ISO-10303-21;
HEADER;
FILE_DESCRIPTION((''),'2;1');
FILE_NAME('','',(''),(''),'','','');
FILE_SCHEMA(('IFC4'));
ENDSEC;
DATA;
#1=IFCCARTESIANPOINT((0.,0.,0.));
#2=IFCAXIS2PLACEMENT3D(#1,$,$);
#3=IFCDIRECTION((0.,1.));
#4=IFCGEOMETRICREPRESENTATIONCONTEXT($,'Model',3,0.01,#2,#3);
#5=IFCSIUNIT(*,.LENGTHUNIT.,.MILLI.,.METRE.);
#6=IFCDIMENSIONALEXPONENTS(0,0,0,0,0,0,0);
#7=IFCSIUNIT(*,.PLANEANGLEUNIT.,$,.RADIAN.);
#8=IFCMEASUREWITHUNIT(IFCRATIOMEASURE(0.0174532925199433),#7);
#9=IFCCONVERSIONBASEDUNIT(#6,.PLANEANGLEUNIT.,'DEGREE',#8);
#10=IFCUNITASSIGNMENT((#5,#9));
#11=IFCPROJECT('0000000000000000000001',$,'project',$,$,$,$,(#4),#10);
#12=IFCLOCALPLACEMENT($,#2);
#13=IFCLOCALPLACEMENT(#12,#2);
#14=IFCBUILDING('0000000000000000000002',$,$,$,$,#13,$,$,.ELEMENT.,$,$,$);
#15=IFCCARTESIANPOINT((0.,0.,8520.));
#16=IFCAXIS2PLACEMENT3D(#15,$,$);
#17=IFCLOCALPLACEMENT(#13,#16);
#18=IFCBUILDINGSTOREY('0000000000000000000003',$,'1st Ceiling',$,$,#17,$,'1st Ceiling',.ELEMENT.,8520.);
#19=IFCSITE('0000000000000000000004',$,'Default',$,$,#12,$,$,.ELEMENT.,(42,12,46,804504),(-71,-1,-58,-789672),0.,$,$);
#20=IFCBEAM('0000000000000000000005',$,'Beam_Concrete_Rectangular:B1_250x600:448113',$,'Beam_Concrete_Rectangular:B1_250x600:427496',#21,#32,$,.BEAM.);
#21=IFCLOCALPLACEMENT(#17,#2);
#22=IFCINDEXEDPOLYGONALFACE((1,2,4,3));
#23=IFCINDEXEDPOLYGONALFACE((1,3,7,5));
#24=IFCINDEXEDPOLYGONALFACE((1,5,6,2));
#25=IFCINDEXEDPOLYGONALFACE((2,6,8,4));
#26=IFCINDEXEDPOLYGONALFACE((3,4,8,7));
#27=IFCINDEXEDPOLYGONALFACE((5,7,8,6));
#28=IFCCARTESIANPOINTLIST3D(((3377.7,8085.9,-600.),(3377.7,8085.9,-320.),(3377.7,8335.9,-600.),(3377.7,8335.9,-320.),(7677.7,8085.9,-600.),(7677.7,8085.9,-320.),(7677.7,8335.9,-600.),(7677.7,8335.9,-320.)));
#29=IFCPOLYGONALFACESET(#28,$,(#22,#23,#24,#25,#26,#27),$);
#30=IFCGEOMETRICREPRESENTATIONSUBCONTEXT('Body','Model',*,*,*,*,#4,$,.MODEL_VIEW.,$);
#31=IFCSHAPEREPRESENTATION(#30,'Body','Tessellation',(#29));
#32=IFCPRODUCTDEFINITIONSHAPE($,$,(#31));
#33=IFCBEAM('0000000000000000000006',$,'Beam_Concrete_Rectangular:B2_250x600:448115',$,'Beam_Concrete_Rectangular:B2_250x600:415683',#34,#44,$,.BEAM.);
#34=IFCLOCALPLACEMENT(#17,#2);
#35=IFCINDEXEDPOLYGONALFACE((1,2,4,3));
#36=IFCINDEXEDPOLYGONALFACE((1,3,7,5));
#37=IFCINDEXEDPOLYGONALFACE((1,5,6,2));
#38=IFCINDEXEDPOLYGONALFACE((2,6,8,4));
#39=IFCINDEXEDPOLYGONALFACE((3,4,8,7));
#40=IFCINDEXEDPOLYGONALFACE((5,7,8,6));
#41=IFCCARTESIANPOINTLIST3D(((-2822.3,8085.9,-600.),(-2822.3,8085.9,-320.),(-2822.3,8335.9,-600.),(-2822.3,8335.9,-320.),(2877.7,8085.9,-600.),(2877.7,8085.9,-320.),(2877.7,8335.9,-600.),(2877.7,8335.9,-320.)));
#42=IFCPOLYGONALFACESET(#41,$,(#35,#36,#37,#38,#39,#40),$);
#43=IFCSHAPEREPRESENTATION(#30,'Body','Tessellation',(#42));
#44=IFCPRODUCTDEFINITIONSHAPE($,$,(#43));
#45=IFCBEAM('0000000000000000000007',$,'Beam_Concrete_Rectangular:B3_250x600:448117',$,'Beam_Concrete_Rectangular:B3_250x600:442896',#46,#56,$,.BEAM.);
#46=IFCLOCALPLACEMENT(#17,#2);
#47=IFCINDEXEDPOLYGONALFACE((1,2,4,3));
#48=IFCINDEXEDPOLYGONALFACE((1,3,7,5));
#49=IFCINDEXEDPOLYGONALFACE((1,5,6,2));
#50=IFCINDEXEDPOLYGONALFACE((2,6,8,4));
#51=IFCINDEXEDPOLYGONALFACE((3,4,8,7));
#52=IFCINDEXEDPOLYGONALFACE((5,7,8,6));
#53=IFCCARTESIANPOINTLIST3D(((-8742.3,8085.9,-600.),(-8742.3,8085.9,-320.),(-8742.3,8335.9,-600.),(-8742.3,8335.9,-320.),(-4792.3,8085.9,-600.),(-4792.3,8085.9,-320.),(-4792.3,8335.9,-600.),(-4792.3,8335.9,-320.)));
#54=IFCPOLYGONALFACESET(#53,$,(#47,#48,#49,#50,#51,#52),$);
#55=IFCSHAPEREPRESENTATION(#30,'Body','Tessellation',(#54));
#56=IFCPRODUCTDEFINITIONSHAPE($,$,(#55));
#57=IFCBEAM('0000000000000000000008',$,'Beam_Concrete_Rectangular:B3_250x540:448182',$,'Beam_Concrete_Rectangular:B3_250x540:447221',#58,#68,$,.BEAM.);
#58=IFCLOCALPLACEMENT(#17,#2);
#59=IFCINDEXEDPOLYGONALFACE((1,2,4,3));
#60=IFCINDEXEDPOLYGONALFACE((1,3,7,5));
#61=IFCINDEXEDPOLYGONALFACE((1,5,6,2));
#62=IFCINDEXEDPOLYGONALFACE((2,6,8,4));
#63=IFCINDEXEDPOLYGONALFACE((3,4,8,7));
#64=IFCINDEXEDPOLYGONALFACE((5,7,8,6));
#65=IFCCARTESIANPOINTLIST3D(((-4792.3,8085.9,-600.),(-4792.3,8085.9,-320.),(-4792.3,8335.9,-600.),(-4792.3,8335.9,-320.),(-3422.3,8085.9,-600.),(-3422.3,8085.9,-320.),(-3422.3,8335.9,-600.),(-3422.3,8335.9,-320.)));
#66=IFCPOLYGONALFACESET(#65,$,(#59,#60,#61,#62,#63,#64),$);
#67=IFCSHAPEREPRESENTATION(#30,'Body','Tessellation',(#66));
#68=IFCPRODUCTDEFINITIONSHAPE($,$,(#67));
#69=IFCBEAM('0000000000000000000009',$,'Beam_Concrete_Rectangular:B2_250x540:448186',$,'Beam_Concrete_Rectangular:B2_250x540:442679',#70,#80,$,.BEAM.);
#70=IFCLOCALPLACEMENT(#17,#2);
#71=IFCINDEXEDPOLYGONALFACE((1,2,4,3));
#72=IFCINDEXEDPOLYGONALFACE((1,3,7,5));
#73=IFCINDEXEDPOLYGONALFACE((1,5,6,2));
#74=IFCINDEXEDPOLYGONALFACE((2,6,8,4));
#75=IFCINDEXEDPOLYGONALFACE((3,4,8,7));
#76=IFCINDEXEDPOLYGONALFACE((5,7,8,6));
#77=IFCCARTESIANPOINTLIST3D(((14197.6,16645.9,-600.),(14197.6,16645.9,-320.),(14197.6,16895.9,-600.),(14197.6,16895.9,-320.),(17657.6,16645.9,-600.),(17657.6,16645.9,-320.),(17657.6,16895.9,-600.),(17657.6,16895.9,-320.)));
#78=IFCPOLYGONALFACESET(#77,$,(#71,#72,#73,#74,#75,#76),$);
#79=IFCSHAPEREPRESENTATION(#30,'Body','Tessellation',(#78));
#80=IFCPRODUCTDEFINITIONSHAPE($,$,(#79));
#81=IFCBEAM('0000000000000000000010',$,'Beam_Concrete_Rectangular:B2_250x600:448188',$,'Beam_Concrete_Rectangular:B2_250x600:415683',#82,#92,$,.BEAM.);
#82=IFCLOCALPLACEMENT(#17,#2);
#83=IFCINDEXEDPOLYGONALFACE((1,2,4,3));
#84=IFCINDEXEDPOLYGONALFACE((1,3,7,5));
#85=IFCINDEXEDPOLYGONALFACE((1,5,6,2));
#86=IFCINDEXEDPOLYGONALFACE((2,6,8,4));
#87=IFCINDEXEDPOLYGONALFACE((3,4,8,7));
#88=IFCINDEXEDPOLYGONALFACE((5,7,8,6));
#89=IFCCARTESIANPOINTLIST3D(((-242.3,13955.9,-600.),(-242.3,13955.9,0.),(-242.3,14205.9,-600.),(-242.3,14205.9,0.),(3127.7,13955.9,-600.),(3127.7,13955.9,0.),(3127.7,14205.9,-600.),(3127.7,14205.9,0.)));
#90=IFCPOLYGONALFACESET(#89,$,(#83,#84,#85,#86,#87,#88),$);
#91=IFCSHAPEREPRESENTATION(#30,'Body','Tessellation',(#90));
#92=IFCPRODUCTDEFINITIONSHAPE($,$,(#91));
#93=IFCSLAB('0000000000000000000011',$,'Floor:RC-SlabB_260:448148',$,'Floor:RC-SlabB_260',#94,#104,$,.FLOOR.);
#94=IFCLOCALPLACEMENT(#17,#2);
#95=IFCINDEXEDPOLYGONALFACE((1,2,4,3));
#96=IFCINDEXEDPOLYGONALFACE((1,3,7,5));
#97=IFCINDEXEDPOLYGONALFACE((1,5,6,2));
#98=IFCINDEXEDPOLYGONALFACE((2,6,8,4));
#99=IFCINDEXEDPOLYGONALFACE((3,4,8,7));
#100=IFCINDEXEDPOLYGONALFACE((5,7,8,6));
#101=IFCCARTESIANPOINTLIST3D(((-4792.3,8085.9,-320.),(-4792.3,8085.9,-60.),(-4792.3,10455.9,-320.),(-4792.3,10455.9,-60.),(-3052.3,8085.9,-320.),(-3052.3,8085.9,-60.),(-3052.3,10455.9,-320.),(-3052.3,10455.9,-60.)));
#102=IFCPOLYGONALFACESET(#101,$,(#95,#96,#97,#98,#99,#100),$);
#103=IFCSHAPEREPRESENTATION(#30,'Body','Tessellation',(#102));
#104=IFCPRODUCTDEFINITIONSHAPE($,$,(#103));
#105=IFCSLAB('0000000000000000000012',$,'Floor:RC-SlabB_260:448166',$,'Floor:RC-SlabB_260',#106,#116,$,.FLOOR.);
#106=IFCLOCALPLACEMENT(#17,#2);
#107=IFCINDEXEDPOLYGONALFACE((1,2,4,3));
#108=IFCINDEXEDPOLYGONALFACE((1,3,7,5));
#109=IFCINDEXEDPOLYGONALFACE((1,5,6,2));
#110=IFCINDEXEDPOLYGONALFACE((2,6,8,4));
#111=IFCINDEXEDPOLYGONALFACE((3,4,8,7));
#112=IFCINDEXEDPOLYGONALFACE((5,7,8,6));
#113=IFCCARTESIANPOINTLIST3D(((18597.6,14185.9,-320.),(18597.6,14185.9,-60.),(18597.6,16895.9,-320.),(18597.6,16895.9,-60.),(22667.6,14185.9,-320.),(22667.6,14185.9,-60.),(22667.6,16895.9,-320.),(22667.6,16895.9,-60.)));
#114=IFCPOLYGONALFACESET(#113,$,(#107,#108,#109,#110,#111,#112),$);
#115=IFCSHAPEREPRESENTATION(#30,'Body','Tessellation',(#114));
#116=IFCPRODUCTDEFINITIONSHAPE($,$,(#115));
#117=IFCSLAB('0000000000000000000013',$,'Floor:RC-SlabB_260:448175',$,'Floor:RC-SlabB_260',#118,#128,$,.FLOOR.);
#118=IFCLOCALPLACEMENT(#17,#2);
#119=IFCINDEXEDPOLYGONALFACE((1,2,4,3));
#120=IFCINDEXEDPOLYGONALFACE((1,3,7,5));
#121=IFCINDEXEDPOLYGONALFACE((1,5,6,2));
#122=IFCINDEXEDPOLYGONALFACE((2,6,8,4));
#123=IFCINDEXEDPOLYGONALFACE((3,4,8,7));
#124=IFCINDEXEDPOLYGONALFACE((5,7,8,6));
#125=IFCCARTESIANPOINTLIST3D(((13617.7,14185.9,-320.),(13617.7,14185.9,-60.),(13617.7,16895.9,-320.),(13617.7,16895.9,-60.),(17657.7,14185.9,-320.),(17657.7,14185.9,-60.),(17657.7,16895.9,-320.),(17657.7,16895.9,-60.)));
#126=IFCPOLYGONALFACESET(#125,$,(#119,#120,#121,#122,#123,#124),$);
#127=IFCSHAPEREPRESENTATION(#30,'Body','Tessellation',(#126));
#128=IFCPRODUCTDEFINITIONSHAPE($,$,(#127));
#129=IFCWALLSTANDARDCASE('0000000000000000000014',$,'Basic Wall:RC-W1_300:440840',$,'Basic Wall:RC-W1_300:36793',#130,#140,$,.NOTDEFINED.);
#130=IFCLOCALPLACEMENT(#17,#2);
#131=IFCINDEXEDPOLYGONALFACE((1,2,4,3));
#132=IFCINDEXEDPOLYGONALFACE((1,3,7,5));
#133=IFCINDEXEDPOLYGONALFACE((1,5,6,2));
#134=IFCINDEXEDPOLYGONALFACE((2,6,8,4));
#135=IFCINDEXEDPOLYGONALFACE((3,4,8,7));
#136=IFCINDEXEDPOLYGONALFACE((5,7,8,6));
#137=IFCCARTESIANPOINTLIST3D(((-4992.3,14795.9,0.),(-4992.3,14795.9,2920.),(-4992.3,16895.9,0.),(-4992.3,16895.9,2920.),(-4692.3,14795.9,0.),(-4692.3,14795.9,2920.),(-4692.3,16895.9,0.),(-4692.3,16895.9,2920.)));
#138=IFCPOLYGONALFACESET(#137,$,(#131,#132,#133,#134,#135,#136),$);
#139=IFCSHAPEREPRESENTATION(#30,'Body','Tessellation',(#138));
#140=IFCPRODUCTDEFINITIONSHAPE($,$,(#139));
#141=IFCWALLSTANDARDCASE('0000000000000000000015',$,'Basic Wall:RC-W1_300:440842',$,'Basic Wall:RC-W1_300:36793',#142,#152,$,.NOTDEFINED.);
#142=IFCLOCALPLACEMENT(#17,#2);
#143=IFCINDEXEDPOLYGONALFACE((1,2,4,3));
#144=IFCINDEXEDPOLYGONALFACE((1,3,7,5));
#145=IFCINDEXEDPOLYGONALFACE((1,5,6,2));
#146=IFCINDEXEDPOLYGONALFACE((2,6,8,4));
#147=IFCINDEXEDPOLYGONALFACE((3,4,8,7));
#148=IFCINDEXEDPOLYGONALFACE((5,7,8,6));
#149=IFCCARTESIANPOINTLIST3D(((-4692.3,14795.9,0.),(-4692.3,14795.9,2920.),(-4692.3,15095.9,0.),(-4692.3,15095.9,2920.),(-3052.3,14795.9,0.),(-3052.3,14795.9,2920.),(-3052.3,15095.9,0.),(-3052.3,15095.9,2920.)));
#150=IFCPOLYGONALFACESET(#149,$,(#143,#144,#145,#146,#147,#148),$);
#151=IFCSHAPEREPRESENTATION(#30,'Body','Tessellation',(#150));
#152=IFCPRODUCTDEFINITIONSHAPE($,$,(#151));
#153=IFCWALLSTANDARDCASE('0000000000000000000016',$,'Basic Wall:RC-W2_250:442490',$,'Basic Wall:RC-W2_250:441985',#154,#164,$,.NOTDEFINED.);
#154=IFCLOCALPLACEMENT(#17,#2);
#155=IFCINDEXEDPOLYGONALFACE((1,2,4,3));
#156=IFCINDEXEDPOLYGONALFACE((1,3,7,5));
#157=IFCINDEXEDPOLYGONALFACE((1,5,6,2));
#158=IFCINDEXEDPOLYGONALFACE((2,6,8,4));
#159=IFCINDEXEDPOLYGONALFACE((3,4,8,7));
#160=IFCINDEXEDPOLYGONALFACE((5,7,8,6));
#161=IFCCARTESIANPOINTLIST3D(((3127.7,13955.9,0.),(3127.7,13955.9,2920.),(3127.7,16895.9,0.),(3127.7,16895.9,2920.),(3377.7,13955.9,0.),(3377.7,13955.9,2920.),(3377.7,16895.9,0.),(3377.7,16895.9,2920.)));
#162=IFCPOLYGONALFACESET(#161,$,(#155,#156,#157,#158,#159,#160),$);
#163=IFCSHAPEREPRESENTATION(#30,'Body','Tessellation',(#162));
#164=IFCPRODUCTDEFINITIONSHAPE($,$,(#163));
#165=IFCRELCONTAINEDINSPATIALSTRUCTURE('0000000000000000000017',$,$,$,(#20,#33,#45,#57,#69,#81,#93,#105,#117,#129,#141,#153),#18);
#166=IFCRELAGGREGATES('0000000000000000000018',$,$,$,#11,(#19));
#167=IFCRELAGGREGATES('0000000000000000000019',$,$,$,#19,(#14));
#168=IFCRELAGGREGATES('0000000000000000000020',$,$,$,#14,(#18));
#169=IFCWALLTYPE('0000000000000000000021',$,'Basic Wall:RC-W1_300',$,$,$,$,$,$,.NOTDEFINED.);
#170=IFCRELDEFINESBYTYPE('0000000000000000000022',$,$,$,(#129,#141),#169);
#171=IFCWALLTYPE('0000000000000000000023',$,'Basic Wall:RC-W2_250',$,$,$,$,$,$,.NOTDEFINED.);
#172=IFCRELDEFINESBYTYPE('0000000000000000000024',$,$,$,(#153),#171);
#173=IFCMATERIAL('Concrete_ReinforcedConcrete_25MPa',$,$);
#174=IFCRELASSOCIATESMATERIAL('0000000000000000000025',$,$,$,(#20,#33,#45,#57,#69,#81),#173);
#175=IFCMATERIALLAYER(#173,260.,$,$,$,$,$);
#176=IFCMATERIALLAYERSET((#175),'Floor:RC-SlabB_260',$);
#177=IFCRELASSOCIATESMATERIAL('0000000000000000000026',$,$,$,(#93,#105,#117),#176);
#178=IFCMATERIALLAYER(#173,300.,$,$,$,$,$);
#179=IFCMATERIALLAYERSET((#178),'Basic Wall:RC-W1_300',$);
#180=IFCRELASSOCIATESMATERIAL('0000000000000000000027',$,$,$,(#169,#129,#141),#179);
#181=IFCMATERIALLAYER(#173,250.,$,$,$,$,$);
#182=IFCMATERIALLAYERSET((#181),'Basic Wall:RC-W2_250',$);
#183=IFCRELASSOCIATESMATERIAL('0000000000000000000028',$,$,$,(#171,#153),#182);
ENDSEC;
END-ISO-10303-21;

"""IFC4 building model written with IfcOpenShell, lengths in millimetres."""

from ifc_helpers import new_model, entity, si_unit, converted_unit, direction, frame, frame_2d, origin, origin_2d_with_axis, place, context, subcontext, project, spatial, polyline, rectangle, extrude, clip, bounded_halfspace, material, layer, layer_set, layer_usage, type_object, element, save


model = new_model("IFC4")

# Units and contexts
model_context = context("Model", 3, precision=0.01, world=origin(), true_north=direction((0.0, 1.0)))
body_context = subcontext(model_context, "Body", "Model", "MODEL_VIEW")
ifc_project = project(units=[si_unit("LENGTHUNIT", "METRE", prefix="MILLI"), converted_unit("PLANEANGLEUNIT", "DEGREE", entity("IfcRatioMeasure", 0.0174532925199433), si_unit("PLANEANGLEUNIT", "RADIAN"), dimensions=[0, 0, 0, 0, 0, 0, 0])], contexts=[model_context])

# Site, building, storey
site_placement = place(None, origin())
site = spatial("IfcSite", under=ifc_project, at=site_placement, Name="Default", CompositionType="ELEMENT", RefLatitude=(42, 12, 46, 804504), RefLongitude=(-71, -1, -58, -789672), RefElevation=0.0)
building_placement = place(site_placement, origin())
building = spatial("IfcBuilding", under=site, at=building_placement, CompositionType="ELEMENT")
storey_placement = place(building_placement, frame((0.0, 0.0, 8520.0)))
storey = spatial("IfcBuildingStorey", under=building, at=storey_placement, Name="1st Ceiling", LongName="1st Ceiling", CompositionType="ELEMENT", Elevation=8520.0)

# Shared definitions
ifc_material = material(Name="Concrete_ReinforcedConcrete_25MPa")

# Beams
beam_1_placement = place(storey_placement, frame((3127.7, 8085.9, 0.0)))
element("IfcBeam", 1, at=beam_1_placement, inside=storey, material=ifc_material, Name="Beam_Concrete_Rectangular:B1_250x600:448113", ObjectType="Beam_Concrete_Rectangular:B1_250x600:427496", PredefinedType="BEAM", context=body_context, shape_type="SweptSolid", body=[
    extrude(rectangle(XDim=280.0, YDim=250.0, at=frame_2d((0.0, 0.0), x_axis=(1.0, 0.0))), frame((250.0, 125.0, -460.0), z_axis=(1.0, 0.0, 0.0), x_axis=(0.0, 0.0, -1.0)), (0.0, 0.0, 1.0), 4300.0),
])
beam_2_placement = place(storey_placement, frame((-3122.3, 8085.9, 0.0)))
element("IfcBeam", 2, at=beam_2_placement, inside=storey, material=ifc_material, Name="Beam_Concrete_Rectangular:B2_250x600:448115", ObjectType="Beam_Concrete_Rectangular:B2_250x600:415683", PredefinedType="BEAM", context=body_context, shape_type="SweptSolid", body=[
    extrude(rectangle(XDim=280.0, YDim=250.0, at=frame_2d((0.0, 0.0), x_axis=(1.0, 0.0))), frame((300.0, 125.0, -460.0), z_axis=(1.0, 0.0, 0.0), x_axis=(0.0, 0.0, -1.0)), (0.0, 0.0, 1.0), 5700.0),
])
beam_3_placement = place(storey_placement, frame((-8992.3, 8085.9, 0.0)))
element("IfcBeam", 3, at=beam_3_placement, inside=storey, material=ifc_material, Name="Beam_Concrete_Rectangular:B3_250x600:448117", ObjectType="Beam_Concrete_Rectangular:B3_250x600:442896", PredefinedType="BEAM", context=body_context, shape_type="SweptSolid", body=[
    extrude(rectangle(XDim=280.0, YDim=250.0, at=frame_2d((0.0, 0.0), x_axis=(1.0, 0.0))), frame((250.0, 125.0, -460.0), z_axis=(1.0, 0.0, 0.0), x_axis=(0.0, 0.0, -1.0)), (0.0, 0.0, 1.0), 3950.0),
])
beam_4_placement = place(storey_placement, frame((-4792.3, 8085.9, 0.0)))
element("IfcBeam", 4, at=beam_4_placement, inside=storey, material=ifc_material, Name="Beam_Concrete_Rectangular:B3_250x540:448182", ObjectType="Beam_Concrete_Rectangular:B3_250x540:447221", PredefinedType="BEAM", context=body_context, shape_type="SweptSolid", body=[
    extrude(rectangle(XDim=280.0, YDim=250.0, at=frame_2d((0.0, 0.0), x_axis=(1.0, 0.0))), frame((0.0, 125.0, -460.0), z_axis=(1.0, 0.0, 0.0), x_axis=(0.0, 0.0, -1.0)), (0.0, 0.0, 1.0), 1370.0),
])
beam_5_placement = place(storey_placement, frame((17657.6, 16895.9, 0.0), z_axis=(0.0, 0.0, 1.0), x_axis=(-1.0, 0.0, 0.0)))
element("IfcBeam", 5, at=beam_5_placement, inside=storey, material=ifc_material, Name="Beam_Concrete_Rectangular:B2_250x540:448186", ObjectType="Beam_Concrete_Rectangular:B2_250x540:442679", PredefinedType="BEAM", context=body_context, shape_type="SweptSolid", body=[
    extrude(rectangle(XDim=280.0, YDim=250.0, at=origin_2d_with_axis()), frame((0.0, 125.0, -460.0), z_axis=(1.0, 0.0, 0.0), x_axis=(0.0, 0.0, -1.0)), (0.0, 0.0, 1.0), 3460.0),
])
beam_6_placement = place(storey_placement, frame((3252.7, 14205.9, 0.0), z_axis=(0.0, 0.0, 1.0), x_axis=(-1.0, 0.0, 0.0)))
element("IfcBeam", 6, at=beam_6_placement, inside=storey, material=ifc_material, Name="Beam_Concrete_Rectangular:B2_250x600:448188", ObjectType="Beam_Concrete_Rectangular:B2_250x600:415683", PredefinedType="BEAM", context=body_context, shape_type="SweptSolid", body=[
    extrude(rectangle(XDim=600.0, YDim=250.0, at=origin_2d_with_axis()), frame((125.0, 125.0, -300.0), z_axis=(1.0, 0.0, 0.0), x_axis=(0.0, 0.0, -1.0)), (0.0, 0.0, 1.0), 3370.0),
])

# Slabs
ifc_layer_1 = layer(ifc_material, 260.0)
ifc_layer_set_1 = layer_set([ifc_layer_1], Name="Floor:RC-SlabB_260")
ifc_layer_usage_1 = layer_usage(ifc_layer_set_1, "AXIS3", "POSITIVE", 0.0)
slab_1_placement = place(storey_placement, origin())
element("IfcSlab", 7, at=slab_1_placement, inside=storey, material=ifc_layer_usage_1, Name="Floor:RC-SlabB_260:448148", ObjectType="Floor:RC-SlabB_260", PredefinedType="FLOOR", context=body_context, shape_type="SweptSolid", body=[
    extrude(rectangle(XDim=2370.0, YDim=1740.0, at=frame_2d((0.0, 0.0), x_axis=(1.0, 0.0))), frame((-3922.3, 9270.9, -60.0), z_axis=(0.0, 0.0, -1.0), x_axis=(0.0, 1.0, 0.0)), (0.0, 0.0, 1.0), 260.0),
])
ifc_layer_usage_2 = layer_usage(ifc_layer_set_1, "AXIS3", "POSITIVE", 0.0)
slab_2_placement = place(storey_placement, origin())
element("IfcSlab", 8, at=slab_2_placement, inside=storey, material=ifc_layer_usage_2, Name="Floor:RC-SlabB_260:448166", ObjectType="Floor:RC-SlabB_260", PredefinedType="FLOOR", context=body_context, shape_type="SweptSolid", body=[
    extrude(rectangle(XDim=2710.0, YDim=4070.0, at=frame_2d((0.0, 0.0), x_axis=(1.0, 0.0))), frame((20632.6, 15540.9, -60.0), z_axis=(0.0, 0.0, -1.0), x_axis=(0.0, 1.0, 0.0)), (0.0, 0.0, 1.0), 260.0),
])
ifc_layer_usage_3 = layer_usage(ifc_layer_set_1, "AXIS3", "POSITIVE", 0.0)
slab_3_placement = place(storey_placement, origin())
element("IfcSlab", 9, at=slab_3_placement, inside=storey, material=ifc_layer_usage_3, Name="Floor:RC-SlabB_260:448175", ObjectType="Floor:RC-SlabB_260", PredefinedType="FLOOR", context=body_context, shape_type="SweptSolid", body=[
    extrude(rectangle(XDim=2710.0, YDim=4040.0, at=origin_2d_with_axis()), frame((15637.7, 15540.9, -60.0), z_axis=(0.0, 0.0, -1.0), x_axis=(0.0, 1.0, 0.0)), (0.0, 0.0, 1.0), 260.0),
])

# Walls
ifc_layer_2 = layer(ifc_material, 300.0)
ifc_layer_set_2 = layer_set([ifc_layer_2], Name="Basic Wall:RC-W1_300")
ifc_layer_usage_4 = layer_usage(ifc_layer_set_2, "AXIS2", "NEGATIVE", 150.0)
wall_type_1 = type_object("IfcWallType", Name="Basic Wall:RC-W1_300", PredefinedType="NOTDEFINED", material=ifc_layer_set_2)
wall_1_placement = place(storey_placement, frame((-4842.3, 16895.9, 0.0), z_axis=(0.0, 0.0, 1.0), x_axis=(0.0, -1.0, 0.0)))
element("IfcWallStandardCase", 10, at=wall_1_placement, inside=storey, type_object=wall_type_1, material=ifc_layer_usage_4, Name="Basic Wall:RC-W1_300:440840", ObjectType="Basic Wall:RC-W1_300:36793", PredefinedType="NOTDEFINED", context=body_context, shape_type="SweptSolid", body=[
    extrude(rectangle(XDim=2100.0, YDim=300.0, at=frame_2d((1050.0, 0.0), x_axis=(-1.0, 0.0))), origin(), (0.0, 0.0, 1.0), 2920.0),
])
ifc_layer_usage_5 = layer_usage(ifc_layer_set_2, "AXIS2", "NEGATIVE", 150.0)
wall_2_placement = place(storey_placement, frame((-4692.3, 14945.9, 0.0)))
element("IfcWallStandardCase", 11, at=wall_2_placement, inside=storey, type_object=wall_type_1, material=ifc_layer_usage_5, Name="Basic Wall:RC-W1_300:440842", ObjectType="Basic Wall:RC-W1_300:36793", PredefinedType="NOTDEFINED", context=body_context, shape_type="SweptSolid", body=[
    extrude(rectangle(XDim=1640.0, YDim=300.0, at=frame_2d((820.0, 0.0), x_axis=(-1.0, 0.0))), origin(), (0.0, 0.0, 1.0), 2920.0),
])
ifc_layer_3 = layer(ifc_material, 250.0)
ifc_layer_set_3 = layer_set([ifc_layer_3], Name="Basic Wall:RC-W2_250")
ifc_layer_usage_6 = layer_usage(ifc_layer_set_3, "AXIS2", "NEGATIVE", 125.0)
wall_type_2 = type_object("IfcWallType", Name="Basic Wall:RC-W2_250", PredefinedType="NOTDEFINED", material=ifc_layer_set_3)
wall_3_placement = place(storey_placement, frame((3252.7, 13955.9, 0.0), z_axis=(0.0, 0.0, 1.0), x_axis=(0.0, 1.0, 0.0)))
element("IfcWallStandardCase", 12, at=wall_3_placement, inside=storey, type_object=wall_type_2, material=ifc_layer_usage_6, Name="Basic Wall:RC-W2_250:442490", ObjectType="Basic Wall:RC-W2_250:441985", PredefinedType="NOTDEFINED", context=body_context, shape_type="Clipping", body=[
    clip(extrude(rectangle(XDim=2940.0, YDim=250.0, at=frame_2d((1470.0, 0.0), x_axis=(-1.0, 0.0))), origin(), (0.0, 0.0, 1.0), 2920.0), bounded_halfspace(frame((0.0, -125.0, 2920.0), z_axis=(0.0, 0.0, -1.0), x_axis=(0.0, -1.0, 0.0)), True, frame((0.0, -125.0, 2920.0)), polyline([(0.0, 0.0), (2940.0, 0.0), (2940.0, 250.0), (0.0, 250.0), (0.0, 0.0)]))),
])

save(model, "model.ifc")
